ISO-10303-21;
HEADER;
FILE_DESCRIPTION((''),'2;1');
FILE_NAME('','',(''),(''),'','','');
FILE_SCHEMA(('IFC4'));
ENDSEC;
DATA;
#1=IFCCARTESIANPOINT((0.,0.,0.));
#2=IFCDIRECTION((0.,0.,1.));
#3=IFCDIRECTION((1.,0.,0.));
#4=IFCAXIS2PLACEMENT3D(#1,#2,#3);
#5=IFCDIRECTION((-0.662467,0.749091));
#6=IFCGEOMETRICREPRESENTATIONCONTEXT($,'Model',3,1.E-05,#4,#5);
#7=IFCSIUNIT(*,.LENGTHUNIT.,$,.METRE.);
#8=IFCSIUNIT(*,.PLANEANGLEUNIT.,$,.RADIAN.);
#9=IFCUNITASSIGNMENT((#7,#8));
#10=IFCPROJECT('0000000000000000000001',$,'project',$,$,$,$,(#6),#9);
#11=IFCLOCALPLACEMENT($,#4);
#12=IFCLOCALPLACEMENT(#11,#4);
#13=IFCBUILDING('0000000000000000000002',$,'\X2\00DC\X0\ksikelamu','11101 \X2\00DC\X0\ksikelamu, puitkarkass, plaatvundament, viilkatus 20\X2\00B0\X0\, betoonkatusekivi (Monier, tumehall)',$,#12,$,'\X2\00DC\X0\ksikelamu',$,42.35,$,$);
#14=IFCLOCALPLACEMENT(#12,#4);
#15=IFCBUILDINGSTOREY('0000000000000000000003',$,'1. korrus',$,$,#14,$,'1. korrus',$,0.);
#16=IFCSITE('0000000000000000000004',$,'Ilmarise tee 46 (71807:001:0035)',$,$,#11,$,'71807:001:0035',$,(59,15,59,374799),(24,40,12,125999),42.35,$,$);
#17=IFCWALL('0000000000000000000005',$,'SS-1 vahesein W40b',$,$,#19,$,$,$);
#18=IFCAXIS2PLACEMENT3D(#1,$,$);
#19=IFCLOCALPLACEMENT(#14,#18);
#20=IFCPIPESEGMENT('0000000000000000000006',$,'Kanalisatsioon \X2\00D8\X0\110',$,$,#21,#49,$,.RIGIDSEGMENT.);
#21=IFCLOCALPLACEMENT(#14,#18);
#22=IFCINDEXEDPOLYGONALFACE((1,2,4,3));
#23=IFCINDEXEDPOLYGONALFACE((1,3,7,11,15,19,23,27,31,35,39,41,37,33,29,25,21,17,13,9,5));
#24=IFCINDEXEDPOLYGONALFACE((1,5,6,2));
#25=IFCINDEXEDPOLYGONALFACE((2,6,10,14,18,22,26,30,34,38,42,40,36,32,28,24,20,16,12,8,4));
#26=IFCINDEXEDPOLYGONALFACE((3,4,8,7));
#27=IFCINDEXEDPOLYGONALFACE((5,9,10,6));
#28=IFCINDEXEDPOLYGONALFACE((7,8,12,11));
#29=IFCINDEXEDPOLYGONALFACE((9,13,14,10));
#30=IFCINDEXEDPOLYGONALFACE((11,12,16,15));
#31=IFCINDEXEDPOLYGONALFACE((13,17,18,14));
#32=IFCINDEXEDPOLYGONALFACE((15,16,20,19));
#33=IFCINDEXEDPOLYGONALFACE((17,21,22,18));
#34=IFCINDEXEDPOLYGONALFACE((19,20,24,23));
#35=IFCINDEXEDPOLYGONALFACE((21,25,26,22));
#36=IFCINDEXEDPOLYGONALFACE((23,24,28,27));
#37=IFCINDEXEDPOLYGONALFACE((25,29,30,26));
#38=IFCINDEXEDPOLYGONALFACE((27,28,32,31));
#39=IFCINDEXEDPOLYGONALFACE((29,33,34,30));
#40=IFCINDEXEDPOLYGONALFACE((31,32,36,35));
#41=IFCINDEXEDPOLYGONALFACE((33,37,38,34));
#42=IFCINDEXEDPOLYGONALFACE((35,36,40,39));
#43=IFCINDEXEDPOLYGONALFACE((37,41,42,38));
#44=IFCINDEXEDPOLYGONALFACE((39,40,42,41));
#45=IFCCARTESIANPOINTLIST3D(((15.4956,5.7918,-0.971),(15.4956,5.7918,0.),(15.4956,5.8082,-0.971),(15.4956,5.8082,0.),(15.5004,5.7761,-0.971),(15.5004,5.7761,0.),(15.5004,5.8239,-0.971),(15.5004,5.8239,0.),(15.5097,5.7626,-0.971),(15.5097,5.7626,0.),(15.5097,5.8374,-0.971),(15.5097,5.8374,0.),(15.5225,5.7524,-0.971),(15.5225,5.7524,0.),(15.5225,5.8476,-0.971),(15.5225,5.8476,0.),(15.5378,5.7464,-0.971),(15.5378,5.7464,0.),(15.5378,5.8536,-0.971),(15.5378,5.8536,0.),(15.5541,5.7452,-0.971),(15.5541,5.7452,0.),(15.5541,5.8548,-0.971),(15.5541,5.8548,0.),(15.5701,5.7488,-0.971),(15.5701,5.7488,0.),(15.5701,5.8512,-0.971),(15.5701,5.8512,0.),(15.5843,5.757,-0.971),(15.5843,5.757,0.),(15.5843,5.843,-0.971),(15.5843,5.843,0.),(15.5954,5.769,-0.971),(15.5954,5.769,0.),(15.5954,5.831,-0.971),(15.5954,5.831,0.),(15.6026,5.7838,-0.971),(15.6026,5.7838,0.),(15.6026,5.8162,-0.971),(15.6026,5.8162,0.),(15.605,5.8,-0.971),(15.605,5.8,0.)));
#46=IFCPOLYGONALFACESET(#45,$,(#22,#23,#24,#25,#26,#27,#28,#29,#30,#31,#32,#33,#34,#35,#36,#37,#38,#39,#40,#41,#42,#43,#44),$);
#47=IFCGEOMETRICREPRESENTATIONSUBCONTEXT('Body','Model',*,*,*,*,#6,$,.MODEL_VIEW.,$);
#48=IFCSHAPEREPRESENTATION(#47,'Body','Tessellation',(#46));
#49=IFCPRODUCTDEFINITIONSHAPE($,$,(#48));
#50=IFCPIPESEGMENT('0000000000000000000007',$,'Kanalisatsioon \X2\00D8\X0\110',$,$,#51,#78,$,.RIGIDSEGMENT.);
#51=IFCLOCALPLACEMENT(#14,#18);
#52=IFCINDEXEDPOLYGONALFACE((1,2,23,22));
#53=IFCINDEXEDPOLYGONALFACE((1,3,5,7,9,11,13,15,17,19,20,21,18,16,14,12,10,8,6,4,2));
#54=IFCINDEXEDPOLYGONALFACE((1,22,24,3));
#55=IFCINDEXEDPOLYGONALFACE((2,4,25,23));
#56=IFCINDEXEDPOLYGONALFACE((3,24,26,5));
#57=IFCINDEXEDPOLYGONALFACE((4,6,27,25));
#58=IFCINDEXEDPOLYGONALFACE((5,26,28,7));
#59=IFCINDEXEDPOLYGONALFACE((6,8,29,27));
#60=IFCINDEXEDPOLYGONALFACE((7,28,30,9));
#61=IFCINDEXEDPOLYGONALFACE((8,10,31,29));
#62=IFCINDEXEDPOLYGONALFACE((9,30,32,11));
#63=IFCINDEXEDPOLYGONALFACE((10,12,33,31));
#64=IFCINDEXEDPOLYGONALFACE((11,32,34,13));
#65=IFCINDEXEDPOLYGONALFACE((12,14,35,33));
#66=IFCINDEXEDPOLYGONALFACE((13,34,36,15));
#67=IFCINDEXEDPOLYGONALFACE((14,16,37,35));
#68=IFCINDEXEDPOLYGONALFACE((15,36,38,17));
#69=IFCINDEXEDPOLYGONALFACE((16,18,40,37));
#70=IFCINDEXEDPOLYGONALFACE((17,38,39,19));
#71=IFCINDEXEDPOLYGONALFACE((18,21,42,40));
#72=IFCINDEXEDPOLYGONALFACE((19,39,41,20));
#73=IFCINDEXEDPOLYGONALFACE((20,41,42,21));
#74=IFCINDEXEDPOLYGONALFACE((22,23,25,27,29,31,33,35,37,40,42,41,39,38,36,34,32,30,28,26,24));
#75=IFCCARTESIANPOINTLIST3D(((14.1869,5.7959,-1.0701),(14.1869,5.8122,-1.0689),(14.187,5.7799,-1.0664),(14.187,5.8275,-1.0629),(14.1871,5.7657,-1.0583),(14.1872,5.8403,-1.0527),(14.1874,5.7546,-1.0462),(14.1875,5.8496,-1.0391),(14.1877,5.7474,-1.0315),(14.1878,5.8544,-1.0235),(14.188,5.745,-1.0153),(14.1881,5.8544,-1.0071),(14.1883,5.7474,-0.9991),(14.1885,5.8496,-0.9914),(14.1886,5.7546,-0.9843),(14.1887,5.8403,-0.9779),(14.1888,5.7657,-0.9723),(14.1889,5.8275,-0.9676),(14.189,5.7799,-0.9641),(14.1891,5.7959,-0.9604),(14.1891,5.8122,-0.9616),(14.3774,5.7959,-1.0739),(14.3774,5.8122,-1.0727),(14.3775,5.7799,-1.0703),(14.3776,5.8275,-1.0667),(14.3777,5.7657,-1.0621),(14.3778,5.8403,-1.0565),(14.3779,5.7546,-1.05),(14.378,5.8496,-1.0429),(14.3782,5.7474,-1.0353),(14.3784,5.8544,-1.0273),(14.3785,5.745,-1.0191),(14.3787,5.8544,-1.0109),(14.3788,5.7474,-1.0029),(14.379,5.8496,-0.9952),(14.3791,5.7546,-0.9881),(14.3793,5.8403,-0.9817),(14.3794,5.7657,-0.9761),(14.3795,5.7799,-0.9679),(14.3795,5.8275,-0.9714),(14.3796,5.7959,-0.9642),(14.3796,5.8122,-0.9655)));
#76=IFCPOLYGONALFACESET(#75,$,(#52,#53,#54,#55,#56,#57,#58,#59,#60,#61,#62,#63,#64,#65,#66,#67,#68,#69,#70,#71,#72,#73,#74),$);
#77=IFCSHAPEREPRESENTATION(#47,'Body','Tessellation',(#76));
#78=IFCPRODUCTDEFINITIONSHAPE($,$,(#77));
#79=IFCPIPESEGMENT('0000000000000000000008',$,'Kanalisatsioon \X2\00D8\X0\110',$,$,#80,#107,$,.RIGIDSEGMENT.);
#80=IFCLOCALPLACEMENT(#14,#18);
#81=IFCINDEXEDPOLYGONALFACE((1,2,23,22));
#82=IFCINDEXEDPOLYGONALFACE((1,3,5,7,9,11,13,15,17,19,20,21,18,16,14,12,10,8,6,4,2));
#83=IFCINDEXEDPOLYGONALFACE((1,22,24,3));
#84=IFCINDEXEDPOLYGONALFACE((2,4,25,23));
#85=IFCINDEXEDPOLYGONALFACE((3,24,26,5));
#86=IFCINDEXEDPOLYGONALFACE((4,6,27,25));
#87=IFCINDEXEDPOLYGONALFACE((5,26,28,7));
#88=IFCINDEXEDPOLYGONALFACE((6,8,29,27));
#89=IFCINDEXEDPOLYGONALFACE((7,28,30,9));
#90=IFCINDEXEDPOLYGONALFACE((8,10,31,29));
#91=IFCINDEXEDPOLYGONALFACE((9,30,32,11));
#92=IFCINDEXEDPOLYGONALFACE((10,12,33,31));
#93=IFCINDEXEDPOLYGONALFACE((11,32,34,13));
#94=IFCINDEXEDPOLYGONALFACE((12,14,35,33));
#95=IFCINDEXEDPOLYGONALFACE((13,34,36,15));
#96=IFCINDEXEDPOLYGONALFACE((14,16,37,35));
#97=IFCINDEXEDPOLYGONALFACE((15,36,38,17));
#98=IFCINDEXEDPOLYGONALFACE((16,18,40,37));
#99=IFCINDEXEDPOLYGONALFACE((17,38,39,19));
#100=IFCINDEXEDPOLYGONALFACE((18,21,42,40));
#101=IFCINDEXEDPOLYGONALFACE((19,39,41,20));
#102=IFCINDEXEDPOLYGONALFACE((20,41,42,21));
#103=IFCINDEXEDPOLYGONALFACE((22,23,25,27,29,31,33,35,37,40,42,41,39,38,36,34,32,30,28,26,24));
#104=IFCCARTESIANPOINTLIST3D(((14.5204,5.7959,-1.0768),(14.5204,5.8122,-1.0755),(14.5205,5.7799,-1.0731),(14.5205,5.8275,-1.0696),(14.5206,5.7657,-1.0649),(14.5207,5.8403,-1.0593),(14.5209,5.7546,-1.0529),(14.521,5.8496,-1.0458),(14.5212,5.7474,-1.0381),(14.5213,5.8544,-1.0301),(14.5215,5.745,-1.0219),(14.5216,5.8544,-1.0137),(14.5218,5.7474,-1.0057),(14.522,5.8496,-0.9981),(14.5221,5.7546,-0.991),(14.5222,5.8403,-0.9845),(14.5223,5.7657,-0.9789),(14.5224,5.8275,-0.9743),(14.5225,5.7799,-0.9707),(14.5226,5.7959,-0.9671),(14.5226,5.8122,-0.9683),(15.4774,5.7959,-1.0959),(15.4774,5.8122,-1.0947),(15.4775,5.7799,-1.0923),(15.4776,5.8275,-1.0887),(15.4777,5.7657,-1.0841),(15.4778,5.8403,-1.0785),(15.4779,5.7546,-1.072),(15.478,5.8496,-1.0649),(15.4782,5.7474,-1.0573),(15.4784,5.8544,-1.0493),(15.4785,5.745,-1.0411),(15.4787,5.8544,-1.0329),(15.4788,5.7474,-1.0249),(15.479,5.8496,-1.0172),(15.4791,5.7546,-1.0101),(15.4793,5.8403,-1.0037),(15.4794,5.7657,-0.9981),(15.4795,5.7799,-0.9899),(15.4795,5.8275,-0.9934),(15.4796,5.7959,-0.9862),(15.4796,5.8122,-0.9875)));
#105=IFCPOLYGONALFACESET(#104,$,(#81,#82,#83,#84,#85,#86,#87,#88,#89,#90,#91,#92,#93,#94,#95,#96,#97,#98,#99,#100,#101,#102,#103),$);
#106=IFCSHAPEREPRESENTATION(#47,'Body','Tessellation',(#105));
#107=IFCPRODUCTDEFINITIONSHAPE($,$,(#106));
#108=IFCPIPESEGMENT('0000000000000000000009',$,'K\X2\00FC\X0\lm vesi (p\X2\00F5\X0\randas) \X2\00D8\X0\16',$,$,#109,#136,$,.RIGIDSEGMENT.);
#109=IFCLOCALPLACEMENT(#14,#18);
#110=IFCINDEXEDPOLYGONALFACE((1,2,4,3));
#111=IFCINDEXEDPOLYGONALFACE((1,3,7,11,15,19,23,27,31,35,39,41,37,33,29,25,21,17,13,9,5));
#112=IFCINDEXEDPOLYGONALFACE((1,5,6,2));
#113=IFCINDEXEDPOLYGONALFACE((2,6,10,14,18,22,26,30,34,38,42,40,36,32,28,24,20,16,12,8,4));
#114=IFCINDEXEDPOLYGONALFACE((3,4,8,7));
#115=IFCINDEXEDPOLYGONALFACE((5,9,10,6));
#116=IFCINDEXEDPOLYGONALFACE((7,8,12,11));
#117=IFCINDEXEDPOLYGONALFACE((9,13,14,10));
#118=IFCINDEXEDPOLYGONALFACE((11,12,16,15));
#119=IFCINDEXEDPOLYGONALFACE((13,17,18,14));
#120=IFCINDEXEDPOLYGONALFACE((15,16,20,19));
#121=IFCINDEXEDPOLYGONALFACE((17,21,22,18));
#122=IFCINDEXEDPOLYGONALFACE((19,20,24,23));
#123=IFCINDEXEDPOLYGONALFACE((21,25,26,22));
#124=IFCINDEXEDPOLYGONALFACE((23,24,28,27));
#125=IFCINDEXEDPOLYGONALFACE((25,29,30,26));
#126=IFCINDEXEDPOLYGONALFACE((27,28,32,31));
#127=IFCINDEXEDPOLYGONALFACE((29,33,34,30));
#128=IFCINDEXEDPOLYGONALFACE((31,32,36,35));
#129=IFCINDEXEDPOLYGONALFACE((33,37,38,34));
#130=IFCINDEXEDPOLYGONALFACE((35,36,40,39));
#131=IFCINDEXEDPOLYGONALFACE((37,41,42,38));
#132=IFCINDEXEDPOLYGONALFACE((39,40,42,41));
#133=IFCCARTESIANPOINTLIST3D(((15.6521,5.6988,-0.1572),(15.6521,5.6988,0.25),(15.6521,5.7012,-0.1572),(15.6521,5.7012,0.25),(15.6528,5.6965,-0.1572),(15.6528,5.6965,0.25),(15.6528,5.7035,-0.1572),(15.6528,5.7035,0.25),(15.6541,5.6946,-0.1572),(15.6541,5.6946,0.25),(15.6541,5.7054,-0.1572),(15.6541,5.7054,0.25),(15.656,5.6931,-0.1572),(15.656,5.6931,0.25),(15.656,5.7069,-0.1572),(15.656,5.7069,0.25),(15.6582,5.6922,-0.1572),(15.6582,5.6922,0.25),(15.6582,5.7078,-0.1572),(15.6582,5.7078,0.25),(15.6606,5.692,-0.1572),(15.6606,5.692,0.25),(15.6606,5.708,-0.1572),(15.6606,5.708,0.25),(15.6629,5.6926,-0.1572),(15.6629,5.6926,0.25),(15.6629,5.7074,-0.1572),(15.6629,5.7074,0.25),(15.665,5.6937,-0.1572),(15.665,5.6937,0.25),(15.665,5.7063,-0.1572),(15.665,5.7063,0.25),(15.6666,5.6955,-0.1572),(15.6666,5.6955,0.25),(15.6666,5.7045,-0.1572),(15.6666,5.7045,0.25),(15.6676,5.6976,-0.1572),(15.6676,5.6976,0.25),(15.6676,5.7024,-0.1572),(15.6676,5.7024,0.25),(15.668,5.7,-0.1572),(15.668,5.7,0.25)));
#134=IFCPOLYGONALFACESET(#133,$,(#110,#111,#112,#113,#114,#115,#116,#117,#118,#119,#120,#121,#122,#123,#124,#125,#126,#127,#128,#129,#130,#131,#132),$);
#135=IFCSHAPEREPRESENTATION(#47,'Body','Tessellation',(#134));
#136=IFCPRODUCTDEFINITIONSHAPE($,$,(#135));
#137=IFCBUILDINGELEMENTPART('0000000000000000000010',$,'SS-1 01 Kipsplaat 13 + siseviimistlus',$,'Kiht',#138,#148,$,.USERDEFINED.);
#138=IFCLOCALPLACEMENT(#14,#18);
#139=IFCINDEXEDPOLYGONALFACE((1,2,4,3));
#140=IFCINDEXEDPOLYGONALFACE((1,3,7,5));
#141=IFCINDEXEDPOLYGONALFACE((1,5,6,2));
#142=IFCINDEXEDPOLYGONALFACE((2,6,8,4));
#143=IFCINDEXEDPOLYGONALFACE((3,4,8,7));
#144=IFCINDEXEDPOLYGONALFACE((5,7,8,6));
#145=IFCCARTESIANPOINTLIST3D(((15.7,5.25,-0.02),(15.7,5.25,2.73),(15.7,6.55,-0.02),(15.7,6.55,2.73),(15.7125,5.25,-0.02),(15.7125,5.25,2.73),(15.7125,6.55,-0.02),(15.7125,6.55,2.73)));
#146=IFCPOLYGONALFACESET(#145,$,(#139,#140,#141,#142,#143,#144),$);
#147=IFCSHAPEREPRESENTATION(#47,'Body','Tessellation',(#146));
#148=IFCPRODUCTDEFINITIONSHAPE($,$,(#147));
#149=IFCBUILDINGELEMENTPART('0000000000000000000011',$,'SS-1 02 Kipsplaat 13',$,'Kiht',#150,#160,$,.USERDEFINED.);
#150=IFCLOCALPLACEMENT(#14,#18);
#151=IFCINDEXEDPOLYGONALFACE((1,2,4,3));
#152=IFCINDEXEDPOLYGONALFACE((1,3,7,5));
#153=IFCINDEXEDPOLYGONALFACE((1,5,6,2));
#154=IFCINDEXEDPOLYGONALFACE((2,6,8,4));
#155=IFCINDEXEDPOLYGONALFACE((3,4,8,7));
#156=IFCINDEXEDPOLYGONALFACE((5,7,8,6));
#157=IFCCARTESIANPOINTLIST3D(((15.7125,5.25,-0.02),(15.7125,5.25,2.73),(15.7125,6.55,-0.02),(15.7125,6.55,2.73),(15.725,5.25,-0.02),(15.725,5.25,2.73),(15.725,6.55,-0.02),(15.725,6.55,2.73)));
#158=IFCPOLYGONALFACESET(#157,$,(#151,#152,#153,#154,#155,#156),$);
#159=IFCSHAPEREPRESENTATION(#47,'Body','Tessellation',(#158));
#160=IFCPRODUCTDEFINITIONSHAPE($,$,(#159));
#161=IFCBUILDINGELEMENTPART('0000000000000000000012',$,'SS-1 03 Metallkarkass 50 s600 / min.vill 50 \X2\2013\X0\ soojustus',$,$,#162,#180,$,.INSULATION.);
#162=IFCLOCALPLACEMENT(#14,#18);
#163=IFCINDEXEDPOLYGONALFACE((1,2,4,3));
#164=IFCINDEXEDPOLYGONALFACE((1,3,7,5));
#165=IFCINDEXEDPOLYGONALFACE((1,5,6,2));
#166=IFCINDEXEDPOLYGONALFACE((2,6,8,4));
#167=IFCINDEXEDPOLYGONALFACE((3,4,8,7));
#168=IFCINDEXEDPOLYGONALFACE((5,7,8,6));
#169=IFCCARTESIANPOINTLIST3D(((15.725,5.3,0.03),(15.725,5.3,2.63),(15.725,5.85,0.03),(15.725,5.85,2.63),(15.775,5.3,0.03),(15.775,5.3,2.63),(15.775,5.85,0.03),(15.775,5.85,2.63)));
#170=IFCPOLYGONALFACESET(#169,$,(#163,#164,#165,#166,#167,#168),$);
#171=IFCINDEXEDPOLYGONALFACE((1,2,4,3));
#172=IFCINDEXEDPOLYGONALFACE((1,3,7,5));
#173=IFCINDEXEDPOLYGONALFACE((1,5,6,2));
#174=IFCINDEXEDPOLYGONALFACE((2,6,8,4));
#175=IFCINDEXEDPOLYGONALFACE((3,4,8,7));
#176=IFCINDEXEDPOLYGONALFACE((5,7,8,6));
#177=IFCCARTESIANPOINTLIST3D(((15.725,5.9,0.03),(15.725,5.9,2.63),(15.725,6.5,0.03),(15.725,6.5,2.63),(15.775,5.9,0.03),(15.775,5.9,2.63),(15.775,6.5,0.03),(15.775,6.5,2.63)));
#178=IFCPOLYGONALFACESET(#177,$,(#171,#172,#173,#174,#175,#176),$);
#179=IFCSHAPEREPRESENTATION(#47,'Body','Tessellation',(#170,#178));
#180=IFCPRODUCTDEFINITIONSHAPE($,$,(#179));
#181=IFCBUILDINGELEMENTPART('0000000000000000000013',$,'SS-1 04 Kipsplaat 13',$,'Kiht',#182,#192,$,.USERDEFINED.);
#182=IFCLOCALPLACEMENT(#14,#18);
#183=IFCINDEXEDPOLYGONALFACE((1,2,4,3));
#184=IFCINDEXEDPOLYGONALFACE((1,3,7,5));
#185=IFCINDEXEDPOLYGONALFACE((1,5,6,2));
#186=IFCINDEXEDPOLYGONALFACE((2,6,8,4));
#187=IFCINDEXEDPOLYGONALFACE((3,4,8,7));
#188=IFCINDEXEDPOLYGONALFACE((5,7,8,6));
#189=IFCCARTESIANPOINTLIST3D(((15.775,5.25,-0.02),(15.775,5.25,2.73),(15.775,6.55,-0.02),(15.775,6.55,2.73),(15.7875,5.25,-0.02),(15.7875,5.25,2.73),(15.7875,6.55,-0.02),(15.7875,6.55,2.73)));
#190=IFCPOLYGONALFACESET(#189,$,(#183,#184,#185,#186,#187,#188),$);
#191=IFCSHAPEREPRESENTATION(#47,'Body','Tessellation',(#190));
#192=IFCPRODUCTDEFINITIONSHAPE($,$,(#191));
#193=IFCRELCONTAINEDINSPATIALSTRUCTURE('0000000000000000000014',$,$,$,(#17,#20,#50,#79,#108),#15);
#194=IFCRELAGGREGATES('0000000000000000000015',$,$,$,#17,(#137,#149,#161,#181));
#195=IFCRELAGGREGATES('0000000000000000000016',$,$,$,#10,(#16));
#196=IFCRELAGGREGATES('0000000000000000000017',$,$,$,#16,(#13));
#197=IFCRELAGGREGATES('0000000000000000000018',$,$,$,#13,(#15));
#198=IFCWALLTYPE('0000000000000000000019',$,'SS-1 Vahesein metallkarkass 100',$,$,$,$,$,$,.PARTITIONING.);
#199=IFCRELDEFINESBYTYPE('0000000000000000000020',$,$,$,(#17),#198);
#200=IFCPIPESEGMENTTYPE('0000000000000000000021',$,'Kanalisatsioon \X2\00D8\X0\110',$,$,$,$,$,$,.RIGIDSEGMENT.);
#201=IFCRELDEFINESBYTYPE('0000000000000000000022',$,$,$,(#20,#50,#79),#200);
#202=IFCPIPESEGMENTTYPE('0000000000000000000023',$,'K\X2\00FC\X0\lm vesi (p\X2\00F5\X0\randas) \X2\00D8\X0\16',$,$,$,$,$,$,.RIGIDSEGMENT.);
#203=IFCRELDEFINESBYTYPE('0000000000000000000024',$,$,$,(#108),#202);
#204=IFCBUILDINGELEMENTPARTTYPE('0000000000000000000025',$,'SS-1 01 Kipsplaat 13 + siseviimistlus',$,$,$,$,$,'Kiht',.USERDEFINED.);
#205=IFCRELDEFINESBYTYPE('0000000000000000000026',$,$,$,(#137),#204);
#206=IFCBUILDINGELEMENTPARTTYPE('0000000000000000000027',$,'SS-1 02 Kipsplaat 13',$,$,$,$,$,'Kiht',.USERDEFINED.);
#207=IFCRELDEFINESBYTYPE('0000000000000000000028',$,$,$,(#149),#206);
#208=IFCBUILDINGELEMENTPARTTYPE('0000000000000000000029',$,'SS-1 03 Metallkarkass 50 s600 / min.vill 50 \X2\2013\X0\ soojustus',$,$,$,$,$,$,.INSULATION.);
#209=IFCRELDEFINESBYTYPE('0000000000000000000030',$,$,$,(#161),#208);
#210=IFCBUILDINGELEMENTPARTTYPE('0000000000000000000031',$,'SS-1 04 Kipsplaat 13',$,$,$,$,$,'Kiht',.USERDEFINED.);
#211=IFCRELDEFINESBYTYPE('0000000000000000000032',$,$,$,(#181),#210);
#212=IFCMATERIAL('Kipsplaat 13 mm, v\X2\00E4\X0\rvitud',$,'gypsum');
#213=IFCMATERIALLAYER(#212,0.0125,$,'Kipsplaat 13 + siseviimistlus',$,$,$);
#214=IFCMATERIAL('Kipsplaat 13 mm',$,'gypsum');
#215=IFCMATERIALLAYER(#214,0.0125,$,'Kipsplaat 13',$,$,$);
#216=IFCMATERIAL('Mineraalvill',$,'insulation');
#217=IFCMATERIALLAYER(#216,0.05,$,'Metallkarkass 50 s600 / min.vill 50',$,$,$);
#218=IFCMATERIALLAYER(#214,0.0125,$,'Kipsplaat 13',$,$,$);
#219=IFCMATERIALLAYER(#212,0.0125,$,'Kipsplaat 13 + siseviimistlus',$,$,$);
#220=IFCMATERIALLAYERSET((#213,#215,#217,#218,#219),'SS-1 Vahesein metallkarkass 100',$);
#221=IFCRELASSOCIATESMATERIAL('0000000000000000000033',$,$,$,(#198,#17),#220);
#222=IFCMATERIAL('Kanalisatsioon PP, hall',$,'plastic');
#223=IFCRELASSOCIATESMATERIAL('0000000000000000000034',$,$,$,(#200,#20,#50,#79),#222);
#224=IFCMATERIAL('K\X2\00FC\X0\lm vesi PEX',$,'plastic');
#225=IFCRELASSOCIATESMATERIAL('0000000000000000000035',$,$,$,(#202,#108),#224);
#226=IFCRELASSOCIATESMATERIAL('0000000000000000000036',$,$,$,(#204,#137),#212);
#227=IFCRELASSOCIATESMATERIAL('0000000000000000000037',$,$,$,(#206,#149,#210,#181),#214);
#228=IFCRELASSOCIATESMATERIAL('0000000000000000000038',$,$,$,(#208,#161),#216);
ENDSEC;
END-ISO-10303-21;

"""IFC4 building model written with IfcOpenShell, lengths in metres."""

from ifc_helpers import new_model, si_unit, direction, frame, origin_with_axes, place, context, subcontext, project, spatial, indexed_curve, circle, outline, extrude, material, layer, layer_set, layer_usage, type_object, element, aggregate, save


model = new_model("IFC4")

# Units and contexts
model_context = context("Model", 3, precision=1e-05, world=origin_with_axes(), true_north=direction((-0.662467, 0.749091)))
body_context = subcontext(model_context, "Body", "Model", "MODEL_VIEW")
ifc_project = project(units=[si_unit("LENGTHUNIT", "METRE"), si_unit("PLANEANGLEUNIT", "RADIAN")], contexts=[model_context])

# Site, building, storey
site_placement = place(None, origin_with_axes())
site = spatial("IfcSite", under=ifc_project, at=site_placement, Name="Ilmarise tee 46 (71807:001:0035)", LongName="71807:001:0035", RefLatitude=(59, 15, 59, 374799), RefLongitude=(24, 40, 12, 125999), RefElevation=42.35)
building_placement = place(site_placement, origin_with_axes())
building = spatial("IfcBuilding", under=site, at=building_placement, Name="Üksikelamu", Description="11101 Üksikelamu, puitkarkass, plaatvundament, viilkatus 20°, betoonkatusekivi (Monier, tumehall)", LongName="Üksikelamu", ElevationOfRefHeight=42.35)
storey_placement = place(building_placement, origin_with_axes())
storey = spatial("IfcBuildingStorey", under=building, at=storey_placement, Name="1. korrus", LongName="1. korrus", Elevation=0.0)

# Wall
ifc_material_1 = material(Name="Kipsplaat 13 mm, värvitud", Category="gypsum")
ifc_layer_1 = layer(ifc_material_1, 0.0125, Name="Kipsplaat 13 + siseviimistlus")
ifc_material_2 = material(Name="Kipsplaat 13 mm", Category="gypsum")
ifc_layer_2 = layer(ifc_material_2, 0.0125, Name="Kipsplaat 13")
ifc_material_3 = material(Name="Mineraalvill", Category="insulation")
ifc_layer_3 = layer(ifc_material_3, 0.05, Name="Metallkarkass 50 s600 / min.vill 50")
ifc_layer_4 = layer(ifc_material_2, 0.0125, Name="Kipsplaat 13")
ifc_layer_5 = layer(ifc_material_1, 0.0125, Name="Kipsplaat 13 + siseviimistlus")
ifc_layer_set = layer_set([ifc_layer_1, ifc_layer_2, ifc_layer_3, ifc_layer_4, ifc_layer_5], Name="SS-1 Vahesein metallkarkass 100")
ifc_layer_usage = layer_usage(ifc_layer_set, "AXIS2", "NEGATIVE", 0.0)
wall_type = type_object("IfcWallType", Name="SS-1 Vahesein metallkarkass 100", PredefinedType="PARTITIONING", material=ifc_layer_set)
wall_placement = place(storey_placement, frame((15.7, 5.25, 0.0), z_axis=(0.0, 0.0, 1.0), x_axis=(0.0, 1.0, 0.0)))
wall = element("IfcWall", 1, at=wall_placement, inside=storey, type_object=wall_type, material=ifc_layer_usage, Name="SS-1 vahesein W40b")

# Shared definitions
ifc_material_4 = material(Name="Kanalisatsioon PP, hall", Category="plastic")
ifc_material_5 = material(Name="Külm vesi PEX", Category="plastic")

# Pipe segments
pipe_segment_type_1 = type_object("IfcPipeSegmentType", Name="Kanalisatsioon Ø110", PredefinedType="RIGIDSEGMENT", material=ifc_material_4)
pipe_segment_1_placement = place(storey_placement, frame((15.55, 5.8, 0.0), z_axis=(0.0, 0.0, -1.0), x_axis=(1.0, 0.0, 0.0)))
element("IfcPipeSegment", 2, at=pipe_segment_1_placement, inside=storey, type_object=pipe_segment_type_1, material=ifc_material_4, Name="Kanalisatsioon Ø110", PredefinedType="RIGIDSEGMENT", context=body_context, shape_type="SweptSolid", body=[
    extrude(circle(Radius=0.055), origin_with_axes(), (0.0, 0.0, 1.0), 0.971),
])
pipe_segment_2_placement = place(storey_placement, frame((14.188, 5.8, -1.0153), z_axis=(0.9998, 0.0, -0.019996), x_axis=(0.0, -1.0, 0.0)))
element("IfcPipeSegment", 3, at=pipe_segment_2_placement, inside=storey, type_object=pipe_segment_type_1, material=ifc_material_4, Name="Kanalisatsioon Ø110", PredefinedType="RIGIDSEGMENT", context=body_context, shape_type="SweptSolid", body=[
    extrude(circle(Radius=0.055), origin_with_axes(), (0.0, 0.0, 1.0), 0.1906),
])
pipe_segment_3_placement = place(storey_placement, frame((14.5215, 5.8, -1.0219), z_axis=(0.9998, 0.0, -0.019996), x_axis=(0.0, -1.0, 0.0)))
element("IfcPipeSegment", 4, at=pipe_segment_3_placement, inside=storey, type_object=pipe_segment_type_1, material=ifc_material_4, Name="Kanalisatsioon Ø110", PredefinedType="RIGIDSEGMENT", context=body_context, shape_type="SweptSolid", body=[
    extrude(circle(Radius=0.055), origin_with_axes(), (0.0, 0.0, 1.0), 0.9572),
])
pipe_segment_type_2 = type_object("IfcPipeSegmentType", Name="Külm vesi (põrandas) Ø16", PredefinedType="RIGIDSEGMENT", material=ifc_material_5)
pipe_segment_4_placement = place(storey_placement, frame((15.66, 5.7, -0.1572), z_axis=(0.0, 0.0, 1.0), x_axis=(1.0, 0.0, 0.0)))
element("IfcPipeSegment", 5, at=pipe_segment_4_placement, inside=storey, type_object=pipe_segment_type_2, material=ifc_material_5, Name="Külm vesi (põrandas) Ø16", PredefinedType="RIGIDSEGMENT", context=body_context, shape_type="SweptSolid", body=[
    extrude(circle(Radius=0.008), origin_with_axes(), (0.0, 0.0, 1.0), 0.4072),
])

# Building element parts
building_element_part_type_1 = type_object("IfcBuildingElementPartType", Name="SS-1 01 Kipsplaat 13 + siseviimistlus", ElementType="Kiht", PredefinedType="USERDEFINED", material=ifc_material_1)
building_element_part_1_placement = place(wall_placement, origin_with_axes())
building_element_part_1 = element("IfcBuildingElementPart", 6, at=building_element_part_1_placement, type_object=building_element_part_type_1, material=ifc_material_1, Name="SS-1 01 Kipsplaat 13 + siseviimistlus", ObjectType="Kiht", PredefinedType="USERDEFINED", context=body_context, shape_type="SweptSolid", body=[
    extrude(outline(indexed_curve([(1.3, -0.02), (1.3, 2.73), (0.0, 2.73), (0.0, -0.02), (1.3, -0.02)], self_intersect=False)), frame((0.0, 0.0, 0.0), z_axis=(0.0, -1.0, 0.0), x_axis=(1.0, 0.0, 0.0)), (0.0, 0.0, 1.0), 0.0125),
])
building_element_part_type_2 = type_object("IfcBuildingElementPartType", Name="SS-1 02 Kipsplaat 13", ElementType="Kiht", PredefinedType="USERDEFINED", material=ifc_material_2)
building_element_part_2_placement = place(wall_placement, origin_with_axes())
building_element_part_2 = element("IfcBuildingElementPart", 7, at=building_element_part_2_placement, type_object=building_element_part_type_2, material=ifc_material_2, Name="SS-1 02 Kipsplaat 13", ObjectType="Kiht", PredefinedType="USERDEFINED", context=body_context, shape_type="SweptSolid", body=[
    extrude(outline(indexed_curve([(1.3, -0.02), (1.3, 2.73), (0.0, 2.73), (0.0, -0.02), (1.3, -0.02)], self_intersect=False)), frame((0.0, -0.0125, 0.0), z_axis=(0.0, -1.0, 0.0), x_axis=(1.0, 0.0, 0.0)), (0.0, 0.0, 1.0), 0.0125),
])
building_element_part_type_3 = type_object("IfcBuildingElementPartType", Name="SS-1 03 Metallkarkass 50 s600 / min.vill 50 – soojustus", PredefinedType="INSULATION", material=ifc_material_3)
building_element_part_3_placement = place(wall_placement, origin_with_axes())
building_element_part_3 = element("IfcBuildingElementPart", 8, at=building_element_part_3_placement, type_object=building_element_part_type_3, material=ifc_material_3, Name="SS-1 03 Metallkarkass 50 s600 / min.vill 50 – soojustus", PredefinedType="INSULATION", context=body_context, shape_type="SweptSolid", body=[
    extrude(outline(indexed_curve([(0.05, 0.03), (0.05, 2.63), (0.6, 2.63), (0.6, 0.03), (0.05, 0.03)], self_intersect=False)), frame((0.0, -0.025, 0.0), z_axis=(0.0, -1.0, 0.0), x_axis=(1.0, 0.0, 0.0)), (0.0, 0.0, 1.0), 0.05),
    extrude(outline(indexed_curve([(1.25, 0.03), (0.65, 0.03), (0.65, 2.63), (1.25, 2.63), (1.25, 0.03)], self_intersect=False)), frame((0.0, -0.025, 0.0), z_axis=(0.0, -1.0, 0.0), x_axis=(1.0, 0.0, 0.0)), (0.0, 0.0, 1.0), 0.05),
])
building_element_part_type_4 = type_object("IfcBuildingElementPartType", Name="SS-1 04 Kipsplaat 13", ElementType="Kiht", PredefinedType="USERDEFINED", material=ifc_material_2)
building_element_part_4_placement = place(wall_placement, origin_with_axes())
building_element_part_4 = element("IfcBuildingElementPart", 9, at=building_element_part_4_placement, type_object=building_element_part_type_4, material=ifc_material_2, Name="SS-1 04 Kipsplaat 13", ObjectType="Kiht", PredefinedType="USERDEFINED", context=body_context, shape_type="SweptSolid", body=[
    extrude(outline(indexed_curve([(1.3, -0.02), (1.3, 2.73), (0.0, 2.73), (0.0, -0.02), (1.3, -0.02)], self_intersect=False)), frame((0.0, -0.075, 0.0), z_axis=(0.0, -1.0, 0.0), x_axis=(1.0, 0.0, 0.0)), (0.0, 0.0, 1.0), 0.0125),
])
aggregate(wall, [building_element_part_1, building_element_part_2, building_element_part_3, building_element_part_4])

save(model, "model.ifc")
